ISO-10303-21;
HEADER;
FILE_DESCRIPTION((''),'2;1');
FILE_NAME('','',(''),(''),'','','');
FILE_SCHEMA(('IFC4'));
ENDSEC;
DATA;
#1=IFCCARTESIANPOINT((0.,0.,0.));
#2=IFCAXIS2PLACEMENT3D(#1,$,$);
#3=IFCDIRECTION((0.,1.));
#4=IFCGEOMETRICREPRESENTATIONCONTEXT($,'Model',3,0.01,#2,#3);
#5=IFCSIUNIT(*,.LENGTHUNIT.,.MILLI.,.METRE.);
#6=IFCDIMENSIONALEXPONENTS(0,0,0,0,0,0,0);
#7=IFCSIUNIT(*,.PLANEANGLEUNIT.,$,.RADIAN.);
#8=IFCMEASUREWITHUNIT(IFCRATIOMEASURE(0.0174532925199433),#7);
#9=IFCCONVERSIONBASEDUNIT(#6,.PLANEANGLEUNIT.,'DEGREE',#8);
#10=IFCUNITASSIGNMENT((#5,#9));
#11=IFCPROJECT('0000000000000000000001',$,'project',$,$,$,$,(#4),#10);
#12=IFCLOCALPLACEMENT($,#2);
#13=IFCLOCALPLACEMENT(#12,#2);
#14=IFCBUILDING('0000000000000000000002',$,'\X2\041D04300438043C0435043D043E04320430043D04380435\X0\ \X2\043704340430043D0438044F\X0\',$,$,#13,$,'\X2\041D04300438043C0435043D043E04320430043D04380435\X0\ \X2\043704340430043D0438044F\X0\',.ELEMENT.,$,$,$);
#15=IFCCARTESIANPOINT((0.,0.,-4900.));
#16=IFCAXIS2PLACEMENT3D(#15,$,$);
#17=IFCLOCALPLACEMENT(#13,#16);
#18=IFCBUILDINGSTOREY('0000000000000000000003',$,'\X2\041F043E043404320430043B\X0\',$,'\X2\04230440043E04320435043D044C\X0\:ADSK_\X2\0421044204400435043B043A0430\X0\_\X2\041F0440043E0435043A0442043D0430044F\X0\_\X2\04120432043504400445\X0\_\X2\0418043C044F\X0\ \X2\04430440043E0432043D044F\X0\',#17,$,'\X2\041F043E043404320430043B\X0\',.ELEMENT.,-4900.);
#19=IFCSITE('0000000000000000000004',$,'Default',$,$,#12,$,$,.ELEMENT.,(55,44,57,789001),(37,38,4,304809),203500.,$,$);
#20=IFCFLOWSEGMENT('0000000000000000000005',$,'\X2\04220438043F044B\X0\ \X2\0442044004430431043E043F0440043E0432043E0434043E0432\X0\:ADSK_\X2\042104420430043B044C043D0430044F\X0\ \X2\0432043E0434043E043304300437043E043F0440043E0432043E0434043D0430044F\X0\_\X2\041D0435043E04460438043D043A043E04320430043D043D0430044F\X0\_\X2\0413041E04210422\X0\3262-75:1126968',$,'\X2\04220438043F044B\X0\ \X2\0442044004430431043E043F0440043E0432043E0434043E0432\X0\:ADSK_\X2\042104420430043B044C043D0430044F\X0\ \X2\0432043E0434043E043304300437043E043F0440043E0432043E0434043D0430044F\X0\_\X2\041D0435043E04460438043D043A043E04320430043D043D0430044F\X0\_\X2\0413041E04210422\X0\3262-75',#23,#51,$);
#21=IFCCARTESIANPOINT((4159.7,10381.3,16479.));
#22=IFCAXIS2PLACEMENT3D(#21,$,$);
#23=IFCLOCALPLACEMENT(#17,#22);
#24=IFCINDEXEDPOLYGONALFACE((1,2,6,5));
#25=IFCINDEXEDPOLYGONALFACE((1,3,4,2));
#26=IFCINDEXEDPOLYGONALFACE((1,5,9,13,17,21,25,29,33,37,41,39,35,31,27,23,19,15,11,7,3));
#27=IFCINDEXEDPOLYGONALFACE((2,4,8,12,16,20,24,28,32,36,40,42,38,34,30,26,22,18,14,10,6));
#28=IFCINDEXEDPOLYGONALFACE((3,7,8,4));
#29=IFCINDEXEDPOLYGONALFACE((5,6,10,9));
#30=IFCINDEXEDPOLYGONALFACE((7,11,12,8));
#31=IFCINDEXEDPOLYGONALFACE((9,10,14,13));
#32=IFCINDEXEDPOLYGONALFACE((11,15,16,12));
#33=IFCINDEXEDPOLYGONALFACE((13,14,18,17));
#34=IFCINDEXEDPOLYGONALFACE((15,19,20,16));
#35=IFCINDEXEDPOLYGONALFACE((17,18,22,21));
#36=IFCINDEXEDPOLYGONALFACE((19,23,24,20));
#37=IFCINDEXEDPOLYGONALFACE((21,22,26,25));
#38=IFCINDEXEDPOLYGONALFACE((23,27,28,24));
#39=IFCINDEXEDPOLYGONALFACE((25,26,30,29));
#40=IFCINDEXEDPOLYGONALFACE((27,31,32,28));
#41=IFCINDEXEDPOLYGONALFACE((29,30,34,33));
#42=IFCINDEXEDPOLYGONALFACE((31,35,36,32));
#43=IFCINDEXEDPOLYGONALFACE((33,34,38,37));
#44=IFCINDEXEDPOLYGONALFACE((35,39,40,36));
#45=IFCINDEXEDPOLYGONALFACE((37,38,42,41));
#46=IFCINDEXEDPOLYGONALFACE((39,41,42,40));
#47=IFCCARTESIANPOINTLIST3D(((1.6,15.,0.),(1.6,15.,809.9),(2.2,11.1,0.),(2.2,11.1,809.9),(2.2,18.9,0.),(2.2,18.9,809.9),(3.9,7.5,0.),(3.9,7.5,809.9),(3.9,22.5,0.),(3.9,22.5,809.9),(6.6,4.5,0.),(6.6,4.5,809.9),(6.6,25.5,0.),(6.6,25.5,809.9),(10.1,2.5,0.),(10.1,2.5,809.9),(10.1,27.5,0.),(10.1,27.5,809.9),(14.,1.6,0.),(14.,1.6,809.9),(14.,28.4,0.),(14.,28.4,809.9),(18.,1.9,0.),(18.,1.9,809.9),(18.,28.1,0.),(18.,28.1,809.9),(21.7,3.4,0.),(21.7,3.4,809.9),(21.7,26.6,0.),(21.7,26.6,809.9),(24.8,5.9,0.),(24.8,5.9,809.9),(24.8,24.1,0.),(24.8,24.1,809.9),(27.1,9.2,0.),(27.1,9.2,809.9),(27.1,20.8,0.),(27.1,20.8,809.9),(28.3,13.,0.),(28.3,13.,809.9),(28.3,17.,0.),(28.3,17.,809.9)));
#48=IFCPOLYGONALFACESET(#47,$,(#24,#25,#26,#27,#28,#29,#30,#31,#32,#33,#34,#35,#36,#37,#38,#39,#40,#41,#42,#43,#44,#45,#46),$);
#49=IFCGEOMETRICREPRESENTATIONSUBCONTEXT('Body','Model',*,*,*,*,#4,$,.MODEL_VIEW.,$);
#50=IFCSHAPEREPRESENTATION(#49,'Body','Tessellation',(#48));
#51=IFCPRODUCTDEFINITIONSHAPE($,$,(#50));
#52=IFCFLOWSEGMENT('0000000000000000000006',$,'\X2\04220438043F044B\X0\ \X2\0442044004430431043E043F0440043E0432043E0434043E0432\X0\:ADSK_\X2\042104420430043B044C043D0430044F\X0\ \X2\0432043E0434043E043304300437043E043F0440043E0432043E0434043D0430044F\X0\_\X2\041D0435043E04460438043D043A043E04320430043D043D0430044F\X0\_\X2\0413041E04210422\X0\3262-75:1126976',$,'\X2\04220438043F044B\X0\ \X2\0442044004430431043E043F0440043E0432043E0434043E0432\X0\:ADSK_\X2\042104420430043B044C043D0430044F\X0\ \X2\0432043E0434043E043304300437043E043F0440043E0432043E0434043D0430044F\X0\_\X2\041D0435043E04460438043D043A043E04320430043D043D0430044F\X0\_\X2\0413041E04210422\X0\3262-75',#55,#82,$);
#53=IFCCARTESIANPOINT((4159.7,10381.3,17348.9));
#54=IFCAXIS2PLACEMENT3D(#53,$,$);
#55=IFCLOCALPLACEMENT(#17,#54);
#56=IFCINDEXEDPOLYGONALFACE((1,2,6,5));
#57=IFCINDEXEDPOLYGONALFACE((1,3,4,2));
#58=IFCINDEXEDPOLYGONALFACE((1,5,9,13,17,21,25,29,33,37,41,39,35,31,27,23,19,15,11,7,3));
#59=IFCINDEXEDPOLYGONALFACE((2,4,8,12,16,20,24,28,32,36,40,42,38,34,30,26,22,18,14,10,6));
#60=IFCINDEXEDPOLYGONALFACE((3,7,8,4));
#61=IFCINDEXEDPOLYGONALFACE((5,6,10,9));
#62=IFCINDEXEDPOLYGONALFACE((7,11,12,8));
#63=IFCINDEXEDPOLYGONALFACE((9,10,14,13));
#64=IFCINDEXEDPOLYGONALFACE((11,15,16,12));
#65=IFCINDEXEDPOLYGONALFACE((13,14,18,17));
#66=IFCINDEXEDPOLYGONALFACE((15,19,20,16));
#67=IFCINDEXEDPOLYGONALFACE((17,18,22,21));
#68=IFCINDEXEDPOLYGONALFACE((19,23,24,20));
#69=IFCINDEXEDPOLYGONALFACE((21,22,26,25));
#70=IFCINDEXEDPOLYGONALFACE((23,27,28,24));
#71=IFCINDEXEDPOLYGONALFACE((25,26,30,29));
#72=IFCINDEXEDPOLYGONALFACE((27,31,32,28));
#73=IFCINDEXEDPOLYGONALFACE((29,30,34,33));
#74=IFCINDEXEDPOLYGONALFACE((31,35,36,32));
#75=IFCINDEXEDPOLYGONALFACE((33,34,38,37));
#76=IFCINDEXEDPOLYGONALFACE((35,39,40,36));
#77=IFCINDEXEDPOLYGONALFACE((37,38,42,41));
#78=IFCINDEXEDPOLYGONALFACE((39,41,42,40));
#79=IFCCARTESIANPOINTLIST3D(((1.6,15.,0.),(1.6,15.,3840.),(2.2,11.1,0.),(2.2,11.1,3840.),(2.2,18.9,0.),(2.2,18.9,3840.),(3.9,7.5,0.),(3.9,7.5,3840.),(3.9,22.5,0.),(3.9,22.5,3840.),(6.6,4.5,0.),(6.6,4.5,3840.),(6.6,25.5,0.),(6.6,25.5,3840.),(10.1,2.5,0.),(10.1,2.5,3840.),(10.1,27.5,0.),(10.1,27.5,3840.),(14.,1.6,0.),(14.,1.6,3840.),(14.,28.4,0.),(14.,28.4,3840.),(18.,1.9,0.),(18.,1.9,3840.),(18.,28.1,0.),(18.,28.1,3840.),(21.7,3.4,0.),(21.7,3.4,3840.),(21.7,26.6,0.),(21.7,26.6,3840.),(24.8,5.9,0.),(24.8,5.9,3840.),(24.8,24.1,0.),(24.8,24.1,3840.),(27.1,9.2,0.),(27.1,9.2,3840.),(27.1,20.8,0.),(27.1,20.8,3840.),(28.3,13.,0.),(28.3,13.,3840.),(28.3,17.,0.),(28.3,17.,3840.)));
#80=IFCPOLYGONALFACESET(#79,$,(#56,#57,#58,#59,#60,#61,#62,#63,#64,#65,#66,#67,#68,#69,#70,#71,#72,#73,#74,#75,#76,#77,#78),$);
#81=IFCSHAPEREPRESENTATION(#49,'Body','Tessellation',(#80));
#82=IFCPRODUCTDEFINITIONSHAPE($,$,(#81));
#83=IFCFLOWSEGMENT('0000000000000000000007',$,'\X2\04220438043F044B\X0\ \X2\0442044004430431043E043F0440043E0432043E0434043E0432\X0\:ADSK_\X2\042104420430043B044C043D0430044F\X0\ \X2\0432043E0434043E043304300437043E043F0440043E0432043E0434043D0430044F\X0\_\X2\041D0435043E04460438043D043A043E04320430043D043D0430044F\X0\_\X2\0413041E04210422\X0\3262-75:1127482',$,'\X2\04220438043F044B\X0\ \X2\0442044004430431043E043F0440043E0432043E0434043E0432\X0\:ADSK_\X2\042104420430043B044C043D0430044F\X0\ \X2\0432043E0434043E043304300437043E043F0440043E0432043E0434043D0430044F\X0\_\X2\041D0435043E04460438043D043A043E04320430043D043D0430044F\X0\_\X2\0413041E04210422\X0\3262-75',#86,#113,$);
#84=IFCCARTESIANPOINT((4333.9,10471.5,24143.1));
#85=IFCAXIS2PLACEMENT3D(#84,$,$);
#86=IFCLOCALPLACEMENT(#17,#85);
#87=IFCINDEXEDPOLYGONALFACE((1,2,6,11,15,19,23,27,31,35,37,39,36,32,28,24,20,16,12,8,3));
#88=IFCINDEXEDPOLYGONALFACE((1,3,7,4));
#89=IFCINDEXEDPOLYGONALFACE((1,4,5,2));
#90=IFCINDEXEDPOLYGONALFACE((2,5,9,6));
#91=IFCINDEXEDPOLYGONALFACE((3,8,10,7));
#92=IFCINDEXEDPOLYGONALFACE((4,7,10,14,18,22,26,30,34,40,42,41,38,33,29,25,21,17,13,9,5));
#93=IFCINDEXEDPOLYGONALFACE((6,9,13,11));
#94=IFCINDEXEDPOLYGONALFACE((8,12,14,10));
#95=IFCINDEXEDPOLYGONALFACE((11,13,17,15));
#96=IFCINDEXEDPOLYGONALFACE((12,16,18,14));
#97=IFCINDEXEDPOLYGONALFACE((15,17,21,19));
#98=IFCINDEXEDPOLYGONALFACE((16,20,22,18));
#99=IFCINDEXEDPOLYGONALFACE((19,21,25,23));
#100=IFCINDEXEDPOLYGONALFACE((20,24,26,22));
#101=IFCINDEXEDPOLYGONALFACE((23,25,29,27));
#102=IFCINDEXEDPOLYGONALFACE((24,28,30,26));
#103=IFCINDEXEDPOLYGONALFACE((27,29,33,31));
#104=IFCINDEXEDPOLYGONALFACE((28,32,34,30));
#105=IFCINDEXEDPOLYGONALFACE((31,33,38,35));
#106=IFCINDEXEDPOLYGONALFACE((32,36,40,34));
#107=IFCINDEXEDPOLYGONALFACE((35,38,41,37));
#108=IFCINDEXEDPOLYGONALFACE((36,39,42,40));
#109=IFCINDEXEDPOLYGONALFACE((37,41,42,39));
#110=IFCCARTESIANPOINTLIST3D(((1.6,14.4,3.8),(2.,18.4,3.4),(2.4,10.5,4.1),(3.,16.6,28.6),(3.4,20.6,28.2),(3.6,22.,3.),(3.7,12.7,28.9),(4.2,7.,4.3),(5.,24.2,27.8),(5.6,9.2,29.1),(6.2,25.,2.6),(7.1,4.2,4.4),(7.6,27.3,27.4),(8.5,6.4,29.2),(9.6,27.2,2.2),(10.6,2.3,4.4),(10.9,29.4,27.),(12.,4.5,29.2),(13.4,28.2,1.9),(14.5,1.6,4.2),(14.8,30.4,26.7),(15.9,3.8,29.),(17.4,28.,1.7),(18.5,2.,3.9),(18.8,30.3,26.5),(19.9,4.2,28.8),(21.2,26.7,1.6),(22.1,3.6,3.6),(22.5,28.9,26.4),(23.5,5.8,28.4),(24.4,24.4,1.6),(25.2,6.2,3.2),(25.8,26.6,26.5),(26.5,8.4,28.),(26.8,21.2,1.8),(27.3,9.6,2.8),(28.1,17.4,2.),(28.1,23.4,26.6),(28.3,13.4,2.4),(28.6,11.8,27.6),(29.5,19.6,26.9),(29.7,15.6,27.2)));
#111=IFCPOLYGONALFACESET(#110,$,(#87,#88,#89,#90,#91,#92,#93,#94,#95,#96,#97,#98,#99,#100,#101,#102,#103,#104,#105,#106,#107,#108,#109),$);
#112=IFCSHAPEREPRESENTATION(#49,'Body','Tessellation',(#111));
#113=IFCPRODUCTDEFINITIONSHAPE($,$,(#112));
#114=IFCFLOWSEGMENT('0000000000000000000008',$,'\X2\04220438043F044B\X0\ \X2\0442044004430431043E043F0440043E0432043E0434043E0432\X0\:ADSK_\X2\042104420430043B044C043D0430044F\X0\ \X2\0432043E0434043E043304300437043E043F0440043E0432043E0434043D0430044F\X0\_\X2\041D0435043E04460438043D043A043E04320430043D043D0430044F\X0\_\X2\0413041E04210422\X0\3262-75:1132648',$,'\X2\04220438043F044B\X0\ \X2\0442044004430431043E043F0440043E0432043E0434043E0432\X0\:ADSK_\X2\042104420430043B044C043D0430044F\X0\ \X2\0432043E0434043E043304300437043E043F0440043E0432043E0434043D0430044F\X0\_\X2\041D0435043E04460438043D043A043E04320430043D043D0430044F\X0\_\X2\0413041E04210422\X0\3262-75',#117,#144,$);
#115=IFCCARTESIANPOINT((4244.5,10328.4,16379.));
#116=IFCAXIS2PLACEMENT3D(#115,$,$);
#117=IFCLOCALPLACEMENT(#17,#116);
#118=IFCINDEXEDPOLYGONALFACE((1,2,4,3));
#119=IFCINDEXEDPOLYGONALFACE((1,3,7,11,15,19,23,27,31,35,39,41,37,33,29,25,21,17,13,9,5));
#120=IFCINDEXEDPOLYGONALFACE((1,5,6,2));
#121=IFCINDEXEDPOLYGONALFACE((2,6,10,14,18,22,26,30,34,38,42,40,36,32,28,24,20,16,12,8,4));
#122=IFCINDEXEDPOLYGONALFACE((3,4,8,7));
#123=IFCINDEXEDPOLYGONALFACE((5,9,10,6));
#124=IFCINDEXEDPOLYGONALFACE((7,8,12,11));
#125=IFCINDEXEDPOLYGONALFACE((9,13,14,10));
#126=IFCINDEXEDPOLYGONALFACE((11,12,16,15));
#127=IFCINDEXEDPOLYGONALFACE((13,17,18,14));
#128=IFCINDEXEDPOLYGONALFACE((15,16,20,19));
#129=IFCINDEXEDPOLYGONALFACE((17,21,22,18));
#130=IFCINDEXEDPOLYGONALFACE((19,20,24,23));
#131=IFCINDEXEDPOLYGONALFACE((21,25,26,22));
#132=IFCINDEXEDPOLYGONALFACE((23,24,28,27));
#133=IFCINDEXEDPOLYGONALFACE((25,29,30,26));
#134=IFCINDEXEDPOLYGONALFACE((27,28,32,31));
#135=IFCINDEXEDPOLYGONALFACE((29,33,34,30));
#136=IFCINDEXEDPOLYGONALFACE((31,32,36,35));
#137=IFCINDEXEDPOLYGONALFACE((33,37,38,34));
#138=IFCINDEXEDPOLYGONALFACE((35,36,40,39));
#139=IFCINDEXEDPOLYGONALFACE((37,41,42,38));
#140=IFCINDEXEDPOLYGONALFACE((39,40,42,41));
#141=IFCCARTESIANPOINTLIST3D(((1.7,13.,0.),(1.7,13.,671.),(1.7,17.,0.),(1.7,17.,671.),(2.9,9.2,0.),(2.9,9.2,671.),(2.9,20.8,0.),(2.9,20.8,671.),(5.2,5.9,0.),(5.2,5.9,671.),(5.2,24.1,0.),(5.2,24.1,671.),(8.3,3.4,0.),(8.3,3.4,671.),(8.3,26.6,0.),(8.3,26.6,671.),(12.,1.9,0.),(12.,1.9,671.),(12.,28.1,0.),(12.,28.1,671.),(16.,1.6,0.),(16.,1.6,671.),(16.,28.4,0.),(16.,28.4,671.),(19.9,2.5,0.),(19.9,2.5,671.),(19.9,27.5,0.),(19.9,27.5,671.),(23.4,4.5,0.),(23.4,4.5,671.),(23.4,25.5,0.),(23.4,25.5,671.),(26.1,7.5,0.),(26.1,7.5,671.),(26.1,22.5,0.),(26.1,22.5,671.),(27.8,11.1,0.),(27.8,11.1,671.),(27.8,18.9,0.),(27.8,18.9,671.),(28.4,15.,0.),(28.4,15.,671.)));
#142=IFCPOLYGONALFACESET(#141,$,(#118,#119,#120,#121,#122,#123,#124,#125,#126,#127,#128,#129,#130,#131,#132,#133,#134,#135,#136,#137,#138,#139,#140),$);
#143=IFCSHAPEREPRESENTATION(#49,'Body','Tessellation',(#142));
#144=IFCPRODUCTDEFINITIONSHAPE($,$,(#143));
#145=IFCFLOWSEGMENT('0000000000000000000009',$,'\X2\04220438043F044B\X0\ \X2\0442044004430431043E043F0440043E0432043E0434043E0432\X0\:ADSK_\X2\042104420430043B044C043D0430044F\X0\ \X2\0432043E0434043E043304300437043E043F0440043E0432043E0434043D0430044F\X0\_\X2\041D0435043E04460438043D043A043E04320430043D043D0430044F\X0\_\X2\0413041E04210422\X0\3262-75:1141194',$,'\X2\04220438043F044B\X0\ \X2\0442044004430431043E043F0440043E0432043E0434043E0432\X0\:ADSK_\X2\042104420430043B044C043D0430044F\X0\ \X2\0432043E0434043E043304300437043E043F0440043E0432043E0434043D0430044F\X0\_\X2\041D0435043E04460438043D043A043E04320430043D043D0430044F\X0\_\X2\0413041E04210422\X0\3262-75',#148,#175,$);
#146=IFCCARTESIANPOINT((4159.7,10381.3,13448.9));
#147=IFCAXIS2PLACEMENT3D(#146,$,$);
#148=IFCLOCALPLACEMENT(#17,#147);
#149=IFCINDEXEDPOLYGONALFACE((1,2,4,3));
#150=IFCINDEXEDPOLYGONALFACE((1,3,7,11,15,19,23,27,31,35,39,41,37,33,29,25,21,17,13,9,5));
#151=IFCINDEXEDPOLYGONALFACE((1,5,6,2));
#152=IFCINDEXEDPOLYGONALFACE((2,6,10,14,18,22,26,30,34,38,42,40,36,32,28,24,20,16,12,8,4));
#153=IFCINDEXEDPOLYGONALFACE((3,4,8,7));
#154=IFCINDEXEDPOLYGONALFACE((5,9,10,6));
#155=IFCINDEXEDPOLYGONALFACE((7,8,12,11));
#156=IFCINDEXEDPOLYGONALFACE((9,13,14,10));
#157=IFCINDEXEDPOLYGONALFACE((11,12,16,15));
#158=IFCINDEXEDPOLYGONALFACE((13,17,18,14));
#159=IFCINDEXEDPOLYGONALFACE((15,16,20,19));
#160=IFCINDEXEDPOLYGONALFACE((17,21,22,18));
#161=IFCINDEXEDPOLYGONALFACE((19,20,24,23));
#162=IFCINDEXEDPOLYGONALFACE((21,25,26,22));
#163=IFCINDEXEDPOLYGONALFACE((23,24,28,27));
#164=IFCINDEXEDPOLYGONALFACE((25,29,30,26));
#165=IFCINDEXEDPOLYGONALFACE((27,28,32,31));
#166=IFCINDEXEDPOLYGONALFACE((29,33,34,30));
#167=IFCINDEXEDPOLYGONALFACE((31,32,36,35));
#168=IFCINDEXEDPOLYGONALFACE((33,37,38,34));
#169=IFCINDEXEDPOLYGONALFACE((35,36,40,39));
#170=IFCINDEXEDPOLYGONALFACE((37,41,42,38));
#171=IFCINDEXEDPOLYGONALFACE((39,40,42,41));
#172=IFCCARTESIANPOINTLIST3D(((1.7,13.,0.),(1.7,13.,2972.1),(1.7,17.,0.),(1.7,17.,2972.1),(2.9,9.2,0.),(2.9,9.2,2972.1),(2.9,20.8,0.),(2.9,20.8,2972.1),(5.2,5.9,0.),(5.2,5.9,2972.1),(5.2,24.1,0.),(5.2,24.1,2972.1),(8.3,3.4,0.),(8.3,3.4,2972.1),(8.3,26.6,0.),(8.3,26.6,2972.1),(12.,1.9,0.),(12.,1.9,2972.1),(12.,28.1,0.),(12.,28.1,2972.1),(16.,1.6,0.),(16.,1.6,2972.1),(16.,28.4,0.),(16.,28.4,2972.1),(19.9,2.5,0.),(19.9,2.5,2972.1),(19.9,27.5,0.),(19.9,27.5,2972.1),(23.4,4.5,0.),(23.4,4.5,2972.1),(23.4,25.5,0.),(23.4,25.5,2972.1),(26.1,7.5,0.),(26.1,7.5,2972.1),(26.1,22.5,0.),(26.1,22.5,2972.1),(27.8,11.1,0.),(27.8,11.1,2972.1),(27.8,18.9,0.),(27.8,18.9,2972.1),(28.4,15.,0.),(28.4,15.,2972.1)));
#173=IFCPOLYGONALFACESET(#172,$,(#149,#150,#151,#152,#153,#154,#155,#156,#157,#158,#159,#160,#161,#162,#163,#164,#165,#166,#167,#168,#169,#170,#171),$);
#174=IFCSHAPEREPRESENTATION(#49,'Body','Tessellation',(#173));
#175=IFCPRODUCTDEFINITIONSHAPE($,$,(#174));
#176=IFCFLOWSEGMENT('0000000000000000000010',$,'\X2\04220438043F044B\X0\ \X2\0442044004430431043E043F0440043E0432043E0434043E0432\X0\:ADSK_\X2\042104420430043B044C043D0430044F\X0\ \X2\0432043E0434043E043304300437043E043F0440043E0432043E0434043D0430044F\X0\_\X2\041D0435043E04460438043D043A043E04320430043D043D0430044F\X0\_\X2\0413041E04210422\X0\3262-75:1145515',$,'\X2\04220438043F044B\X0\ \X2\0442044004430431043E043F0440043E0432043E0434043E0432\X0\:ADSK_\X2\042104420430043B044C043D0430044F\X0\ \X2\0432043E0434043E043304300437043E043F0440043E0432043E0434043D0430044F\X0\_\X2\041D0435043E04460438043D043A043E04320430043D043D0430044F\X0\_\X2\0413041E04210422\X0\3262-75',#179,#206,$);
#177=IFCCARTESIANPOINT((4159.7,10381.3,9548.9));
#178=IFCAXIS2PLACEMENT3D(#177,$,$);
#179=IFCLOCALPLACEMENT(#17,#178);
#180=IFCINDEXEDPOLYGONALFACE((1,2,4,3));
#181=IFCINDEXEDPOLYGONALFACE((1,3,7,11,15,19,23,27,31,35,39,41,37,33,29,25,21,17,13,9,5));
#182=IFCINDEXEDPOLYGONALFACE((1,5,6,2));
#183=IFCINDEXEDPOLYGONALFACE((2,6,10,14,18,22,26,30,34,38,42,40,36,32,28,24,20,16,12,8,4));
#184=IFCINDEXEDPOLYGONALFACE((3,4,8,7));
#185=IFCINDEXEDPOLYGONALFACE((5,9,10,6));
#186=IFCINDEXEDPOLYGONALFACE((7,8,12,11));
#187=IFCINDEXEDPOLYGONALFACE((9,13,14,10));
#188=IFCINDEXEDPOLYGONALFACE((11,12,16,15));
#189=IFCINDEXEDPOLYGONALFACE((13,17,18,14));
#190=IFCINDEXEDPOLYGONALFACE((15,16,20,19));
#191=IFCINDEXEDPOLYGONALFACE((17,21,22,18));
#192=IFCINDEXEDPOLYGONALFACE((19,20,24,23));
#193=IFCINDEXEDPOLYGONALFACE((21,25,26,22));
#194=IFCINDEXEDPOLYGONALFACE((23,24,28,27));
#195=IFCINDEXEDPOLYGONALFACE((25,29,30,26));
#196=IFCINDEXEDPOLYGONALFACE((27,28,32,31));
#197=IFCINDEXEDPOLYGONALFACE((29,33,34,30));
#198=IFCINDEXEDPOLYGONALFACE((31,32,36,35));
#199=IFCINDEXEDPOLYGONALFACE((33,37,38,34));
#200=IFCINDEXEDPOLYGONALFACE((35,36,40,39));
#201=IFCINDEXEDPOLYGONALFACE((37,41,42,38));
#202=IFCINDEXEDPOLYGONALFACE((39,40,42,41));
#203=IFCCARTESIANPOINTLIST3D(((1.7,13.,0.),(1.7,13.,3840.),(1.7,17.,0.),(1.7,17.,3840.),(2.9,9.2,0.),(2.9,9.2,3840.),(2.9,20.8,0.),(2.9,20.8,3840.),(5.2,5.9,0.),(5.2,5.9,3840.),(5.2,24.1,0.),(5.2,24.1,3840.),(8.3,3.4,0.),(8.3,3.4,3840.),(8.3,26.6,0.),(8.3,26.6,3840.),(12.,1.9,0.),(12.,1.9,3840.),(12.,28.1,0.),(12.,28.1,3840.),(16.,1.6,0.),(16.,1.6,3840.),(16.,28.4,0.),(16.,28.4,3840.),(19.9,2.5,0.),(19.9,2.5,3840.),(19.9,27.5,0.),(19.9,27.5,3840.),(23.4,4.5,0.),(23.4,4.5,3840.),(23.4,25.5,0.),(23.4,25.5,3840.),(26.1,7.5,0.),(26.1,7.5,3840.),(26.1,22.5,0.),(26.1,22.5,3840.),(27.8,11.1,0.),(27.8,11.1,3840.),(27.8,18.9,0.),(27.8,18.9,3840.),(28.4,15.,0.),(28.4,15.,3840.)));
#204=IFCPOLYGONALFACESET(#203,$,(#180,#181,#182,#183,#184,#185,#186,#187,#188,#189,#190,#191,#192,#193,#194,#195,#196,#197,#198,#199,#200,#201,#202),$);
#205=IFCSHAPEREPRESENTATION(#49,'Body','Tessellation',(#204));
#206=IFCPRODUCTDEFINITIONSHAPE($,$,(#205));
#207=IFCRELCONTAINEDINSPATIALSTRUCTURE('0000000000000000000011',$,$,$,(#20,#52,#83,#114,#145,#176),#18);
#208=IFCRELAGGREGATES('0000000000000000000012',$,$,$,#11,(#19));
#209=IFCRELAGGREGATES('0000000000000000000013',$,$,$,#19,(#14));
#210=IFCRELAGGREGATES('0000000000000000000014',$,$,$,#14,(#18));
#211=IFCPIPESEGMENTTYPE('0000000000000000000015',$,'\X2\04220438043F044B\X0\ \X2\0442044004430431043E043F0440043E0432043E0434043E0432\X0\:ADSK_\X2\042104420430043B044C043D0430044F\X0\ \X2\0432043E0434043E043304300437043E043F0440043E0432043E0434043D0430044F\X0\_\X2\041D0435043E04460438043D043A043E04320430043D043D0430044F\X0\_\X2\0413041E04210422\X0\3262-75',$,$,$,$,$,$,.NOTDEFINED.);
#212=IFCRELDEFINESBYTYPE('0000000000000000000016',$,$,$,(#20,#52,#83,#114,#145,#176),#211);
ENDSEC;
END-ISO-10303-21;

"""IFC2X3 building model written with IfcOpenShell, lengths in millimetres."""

from ifc_helpers import new_model, entity, si_unit, converted_unit, direction, frame, origin, origin_2d_with_axis, place, context, subcontext, project, spatial, circle, extrude, type_object, element, save


model = new_model("IFC2X3")

# Units and contexts
model_context = context("Model", 3, precision=0.01, world=origin(), true_north=direction((0.0, 1.0)))
body_context = subcontext(model_context, "Body", "Model", "MODEL_VIEW")
ifc_project = project(units=[si_unit("LENGTHUNIT", "METRE", prefix="MILLI"), converted_unit("PLANEANGLEUNIT", "DEGREE", entity("IfcRatioMeasure", 0.0174532925199433), si_unit("PLANEANGLEUNIT", "RADIAN"), dimensions=[0, 0, 0, 0, 0, 0, 0])], contexts=[model_context])

# Site, building, storey
site_placement = place(None, origin())
site = spatial("IfcSite", under=ifc_project, at=site_placement, Name="Default", CompositionType="ELEMENT", RefLatitude=(55, 44, 57, 789001), RefLongitude=(37, 38, 4, 304809), RefElevation=203500.0)
building_placement = place(site_placement, origin())
building = spatial("IfcBuilding", under=site, at=building_placement, Name="Наименование здания", LongName="Наименование здания", CompositionType="ELEMENT")
storey_placement = place(building_placement, frame((0.0, 0.0, -4900.0)))
storey = spatial("IfcBuildingStorey", under=building, at=storey_placement, Name="Подвал", ObjectType="Уровень:ADSK_Стрелка_Проектная_Вверх_Имя уровня", LongName="Подвал", CompositionType="ELEMENT", Elevation=-4900.0)

# Flow segments
pipe_segment_type = type_object("IfcPipeSegmentType", Name="Типы трубопроводов:ADSK_Стальная водогазопроводная_Неоцинкованная_ГОСТ3262-75", PredefinedType="NOTDEFINED")
flow_segment_1_placement = place(storey_placement, frame((4159.7, 10381.3, 16479.0)))
element("IfcFlowSegment", 1, at=flow_segment_1_placement, inside=storey, type_object=pipe_segment_type, Name="Типы трубопроводов:ADSK_Стальная водогазопроводная_Неоцинкованная_ГОСТ3262-75:1126968", ObjectType="Типы трубопроводов:ADSK_Стальная водогазопроводная_Неоцинкованная_ГОСТ3262-75", context=body_context, shape_type="SweptSolid", body=[
    extrude(circle(Radius=13.4, at=origin_2d_with_axis()), frame((15.0, 15.0, 0.0), z_axis=(0.0, 0.0, 1.0), x_axis=(-1.0, 0.0, 0.0)), (0.0, 0.0, 1.0), 809.9),
])
flow_segment_2_placement = place(storey_placement, frame((4159.7, 10381.3, 17348.9)))
element("IfcFlowSegment", 2, at=flow_segment_2_placement, inside=storey, type_object=pipe_segment_type, Name="Типы трубопроводов:ADSK_Стальная водогазопроводная_Неоцинкованная_ГОСТ3262-75:1126976", ObjectType="Типы трубопроводов:ADSK_Стальная водогазопроводная_Неоцинкованная_ГОСТ3262-75", context=body_context, shape_type="SweptSolid", body=[
    extrude(circle(Radius=13.4, at=origin_2d_with_axis()), frame((15.0, 15.0, 0.0), z_axis=(0.0, 0.0, 1.0), x_axis=(-1.0, 0.0, 0.0)), (0.0, 0.0, 1.0), 3840.0),
])
flow_segment_3_placement = place(storey_placement, frame((4333.9, 10471.5, 24143.1)))
element("IfcFlowSegment", 3, at=flow_segment_3_placement, inside=storey, type_object=pipe_segment_type, Name="Типы трубопроводов:ADSK_Стальная водогазопроводная_Неоцинкованная_ГОСТ3262-75:1127482", ObjectType="Типы трубопроводов:ADSK_Стальная водогазопроводная_Неоцинкованная_ГОСТ3262-75", context=body_context, shape_type="SweptSolid", body=[
    extrude(circle(Radius=13.4, at=origin_2d_with_axis()), frame((15.0, 14.9, 3.0), z_axis=(0.055338, 0.088561, 0.994532), x_axis=(-0.848053, 0.529912, 0.0)), (0.0, 0.0, 1.0), 25.0),
])
flow_segment_4_placement = place(storey_placement, frame((4244.5, 10328.4, 16379.0)))
element("IfcFlowSegment", 4, at=flow_segment_4_placement, inside=storey, type_object=pipe_segment_type, Name="Типы трубопроводов:ADSK_Стальная водогазопроводная_Неоцинкованная_ГОСТ3262-75:1132648", ObjectType="Типы трубопроводов:ADSK_Стальная водогазопроводная_Неоцинкованная_ГОСТ3262-75", context=body_context, shape_type="SweptSolid", body=[
    extrude(circle(Radius=13.4, at=origin_2d_with_axis()), frame((15.0, 15.0, 0.0)), (0.0, 0.0, 1.0), 671.0),
])
flow_segment_5_placement = place(storey_placement, frame((4159.7, 10381.3, 13448.9)))
element("IfcFlowSegment", 5, at=flow_segment_5_placement, inside=storey, type_object=pipe_segment_type, Name="Типы трубопроводов:ADSK_Стальная водогазопроводная_Неоцинкованная_ГОСТ3262-75:1141194", ObjectType="Типы трубопроводов:ADSK_Стальная водогазопроводная_Неоцинкованная_ГОСТ3262-75", context=body_context, shape_type="SweptSolid", body=[
    extrude(circle(Radius=13.4, at=origin_2d_with_axis()), frame((15.0, 15.0, 0.0)), (0.0, 0.0, 1.0), 2972.1),
])
flow_segment_6_placement = place(storey_placement, frame((4159.7, 10381.3, 9548.9)))
element("IfcFlowSegment", 6, at=flow_segment_6_placement, inside=storey, type_object=pipe_segment_type, Name="Типы трубопроводов:ADSK_Стальная водогазопроводная_Неоцинкованная_ГОСТ3262-75:1145515", ObjectType="Типы трубопроводов:ADSK_Стальная водогазопроводная_Неоцинкованная_ГОСТ3262-75", context=body_context, shape_type="SweptSolid", body=[
    extrude(circle(Radius=13.4, at=origin_2d_with_axis()), frame((15.0, 15.0, 0.0)), (0.0, 0.0, 1.0), 3840.0),
])

save(model, "model.ifc")
